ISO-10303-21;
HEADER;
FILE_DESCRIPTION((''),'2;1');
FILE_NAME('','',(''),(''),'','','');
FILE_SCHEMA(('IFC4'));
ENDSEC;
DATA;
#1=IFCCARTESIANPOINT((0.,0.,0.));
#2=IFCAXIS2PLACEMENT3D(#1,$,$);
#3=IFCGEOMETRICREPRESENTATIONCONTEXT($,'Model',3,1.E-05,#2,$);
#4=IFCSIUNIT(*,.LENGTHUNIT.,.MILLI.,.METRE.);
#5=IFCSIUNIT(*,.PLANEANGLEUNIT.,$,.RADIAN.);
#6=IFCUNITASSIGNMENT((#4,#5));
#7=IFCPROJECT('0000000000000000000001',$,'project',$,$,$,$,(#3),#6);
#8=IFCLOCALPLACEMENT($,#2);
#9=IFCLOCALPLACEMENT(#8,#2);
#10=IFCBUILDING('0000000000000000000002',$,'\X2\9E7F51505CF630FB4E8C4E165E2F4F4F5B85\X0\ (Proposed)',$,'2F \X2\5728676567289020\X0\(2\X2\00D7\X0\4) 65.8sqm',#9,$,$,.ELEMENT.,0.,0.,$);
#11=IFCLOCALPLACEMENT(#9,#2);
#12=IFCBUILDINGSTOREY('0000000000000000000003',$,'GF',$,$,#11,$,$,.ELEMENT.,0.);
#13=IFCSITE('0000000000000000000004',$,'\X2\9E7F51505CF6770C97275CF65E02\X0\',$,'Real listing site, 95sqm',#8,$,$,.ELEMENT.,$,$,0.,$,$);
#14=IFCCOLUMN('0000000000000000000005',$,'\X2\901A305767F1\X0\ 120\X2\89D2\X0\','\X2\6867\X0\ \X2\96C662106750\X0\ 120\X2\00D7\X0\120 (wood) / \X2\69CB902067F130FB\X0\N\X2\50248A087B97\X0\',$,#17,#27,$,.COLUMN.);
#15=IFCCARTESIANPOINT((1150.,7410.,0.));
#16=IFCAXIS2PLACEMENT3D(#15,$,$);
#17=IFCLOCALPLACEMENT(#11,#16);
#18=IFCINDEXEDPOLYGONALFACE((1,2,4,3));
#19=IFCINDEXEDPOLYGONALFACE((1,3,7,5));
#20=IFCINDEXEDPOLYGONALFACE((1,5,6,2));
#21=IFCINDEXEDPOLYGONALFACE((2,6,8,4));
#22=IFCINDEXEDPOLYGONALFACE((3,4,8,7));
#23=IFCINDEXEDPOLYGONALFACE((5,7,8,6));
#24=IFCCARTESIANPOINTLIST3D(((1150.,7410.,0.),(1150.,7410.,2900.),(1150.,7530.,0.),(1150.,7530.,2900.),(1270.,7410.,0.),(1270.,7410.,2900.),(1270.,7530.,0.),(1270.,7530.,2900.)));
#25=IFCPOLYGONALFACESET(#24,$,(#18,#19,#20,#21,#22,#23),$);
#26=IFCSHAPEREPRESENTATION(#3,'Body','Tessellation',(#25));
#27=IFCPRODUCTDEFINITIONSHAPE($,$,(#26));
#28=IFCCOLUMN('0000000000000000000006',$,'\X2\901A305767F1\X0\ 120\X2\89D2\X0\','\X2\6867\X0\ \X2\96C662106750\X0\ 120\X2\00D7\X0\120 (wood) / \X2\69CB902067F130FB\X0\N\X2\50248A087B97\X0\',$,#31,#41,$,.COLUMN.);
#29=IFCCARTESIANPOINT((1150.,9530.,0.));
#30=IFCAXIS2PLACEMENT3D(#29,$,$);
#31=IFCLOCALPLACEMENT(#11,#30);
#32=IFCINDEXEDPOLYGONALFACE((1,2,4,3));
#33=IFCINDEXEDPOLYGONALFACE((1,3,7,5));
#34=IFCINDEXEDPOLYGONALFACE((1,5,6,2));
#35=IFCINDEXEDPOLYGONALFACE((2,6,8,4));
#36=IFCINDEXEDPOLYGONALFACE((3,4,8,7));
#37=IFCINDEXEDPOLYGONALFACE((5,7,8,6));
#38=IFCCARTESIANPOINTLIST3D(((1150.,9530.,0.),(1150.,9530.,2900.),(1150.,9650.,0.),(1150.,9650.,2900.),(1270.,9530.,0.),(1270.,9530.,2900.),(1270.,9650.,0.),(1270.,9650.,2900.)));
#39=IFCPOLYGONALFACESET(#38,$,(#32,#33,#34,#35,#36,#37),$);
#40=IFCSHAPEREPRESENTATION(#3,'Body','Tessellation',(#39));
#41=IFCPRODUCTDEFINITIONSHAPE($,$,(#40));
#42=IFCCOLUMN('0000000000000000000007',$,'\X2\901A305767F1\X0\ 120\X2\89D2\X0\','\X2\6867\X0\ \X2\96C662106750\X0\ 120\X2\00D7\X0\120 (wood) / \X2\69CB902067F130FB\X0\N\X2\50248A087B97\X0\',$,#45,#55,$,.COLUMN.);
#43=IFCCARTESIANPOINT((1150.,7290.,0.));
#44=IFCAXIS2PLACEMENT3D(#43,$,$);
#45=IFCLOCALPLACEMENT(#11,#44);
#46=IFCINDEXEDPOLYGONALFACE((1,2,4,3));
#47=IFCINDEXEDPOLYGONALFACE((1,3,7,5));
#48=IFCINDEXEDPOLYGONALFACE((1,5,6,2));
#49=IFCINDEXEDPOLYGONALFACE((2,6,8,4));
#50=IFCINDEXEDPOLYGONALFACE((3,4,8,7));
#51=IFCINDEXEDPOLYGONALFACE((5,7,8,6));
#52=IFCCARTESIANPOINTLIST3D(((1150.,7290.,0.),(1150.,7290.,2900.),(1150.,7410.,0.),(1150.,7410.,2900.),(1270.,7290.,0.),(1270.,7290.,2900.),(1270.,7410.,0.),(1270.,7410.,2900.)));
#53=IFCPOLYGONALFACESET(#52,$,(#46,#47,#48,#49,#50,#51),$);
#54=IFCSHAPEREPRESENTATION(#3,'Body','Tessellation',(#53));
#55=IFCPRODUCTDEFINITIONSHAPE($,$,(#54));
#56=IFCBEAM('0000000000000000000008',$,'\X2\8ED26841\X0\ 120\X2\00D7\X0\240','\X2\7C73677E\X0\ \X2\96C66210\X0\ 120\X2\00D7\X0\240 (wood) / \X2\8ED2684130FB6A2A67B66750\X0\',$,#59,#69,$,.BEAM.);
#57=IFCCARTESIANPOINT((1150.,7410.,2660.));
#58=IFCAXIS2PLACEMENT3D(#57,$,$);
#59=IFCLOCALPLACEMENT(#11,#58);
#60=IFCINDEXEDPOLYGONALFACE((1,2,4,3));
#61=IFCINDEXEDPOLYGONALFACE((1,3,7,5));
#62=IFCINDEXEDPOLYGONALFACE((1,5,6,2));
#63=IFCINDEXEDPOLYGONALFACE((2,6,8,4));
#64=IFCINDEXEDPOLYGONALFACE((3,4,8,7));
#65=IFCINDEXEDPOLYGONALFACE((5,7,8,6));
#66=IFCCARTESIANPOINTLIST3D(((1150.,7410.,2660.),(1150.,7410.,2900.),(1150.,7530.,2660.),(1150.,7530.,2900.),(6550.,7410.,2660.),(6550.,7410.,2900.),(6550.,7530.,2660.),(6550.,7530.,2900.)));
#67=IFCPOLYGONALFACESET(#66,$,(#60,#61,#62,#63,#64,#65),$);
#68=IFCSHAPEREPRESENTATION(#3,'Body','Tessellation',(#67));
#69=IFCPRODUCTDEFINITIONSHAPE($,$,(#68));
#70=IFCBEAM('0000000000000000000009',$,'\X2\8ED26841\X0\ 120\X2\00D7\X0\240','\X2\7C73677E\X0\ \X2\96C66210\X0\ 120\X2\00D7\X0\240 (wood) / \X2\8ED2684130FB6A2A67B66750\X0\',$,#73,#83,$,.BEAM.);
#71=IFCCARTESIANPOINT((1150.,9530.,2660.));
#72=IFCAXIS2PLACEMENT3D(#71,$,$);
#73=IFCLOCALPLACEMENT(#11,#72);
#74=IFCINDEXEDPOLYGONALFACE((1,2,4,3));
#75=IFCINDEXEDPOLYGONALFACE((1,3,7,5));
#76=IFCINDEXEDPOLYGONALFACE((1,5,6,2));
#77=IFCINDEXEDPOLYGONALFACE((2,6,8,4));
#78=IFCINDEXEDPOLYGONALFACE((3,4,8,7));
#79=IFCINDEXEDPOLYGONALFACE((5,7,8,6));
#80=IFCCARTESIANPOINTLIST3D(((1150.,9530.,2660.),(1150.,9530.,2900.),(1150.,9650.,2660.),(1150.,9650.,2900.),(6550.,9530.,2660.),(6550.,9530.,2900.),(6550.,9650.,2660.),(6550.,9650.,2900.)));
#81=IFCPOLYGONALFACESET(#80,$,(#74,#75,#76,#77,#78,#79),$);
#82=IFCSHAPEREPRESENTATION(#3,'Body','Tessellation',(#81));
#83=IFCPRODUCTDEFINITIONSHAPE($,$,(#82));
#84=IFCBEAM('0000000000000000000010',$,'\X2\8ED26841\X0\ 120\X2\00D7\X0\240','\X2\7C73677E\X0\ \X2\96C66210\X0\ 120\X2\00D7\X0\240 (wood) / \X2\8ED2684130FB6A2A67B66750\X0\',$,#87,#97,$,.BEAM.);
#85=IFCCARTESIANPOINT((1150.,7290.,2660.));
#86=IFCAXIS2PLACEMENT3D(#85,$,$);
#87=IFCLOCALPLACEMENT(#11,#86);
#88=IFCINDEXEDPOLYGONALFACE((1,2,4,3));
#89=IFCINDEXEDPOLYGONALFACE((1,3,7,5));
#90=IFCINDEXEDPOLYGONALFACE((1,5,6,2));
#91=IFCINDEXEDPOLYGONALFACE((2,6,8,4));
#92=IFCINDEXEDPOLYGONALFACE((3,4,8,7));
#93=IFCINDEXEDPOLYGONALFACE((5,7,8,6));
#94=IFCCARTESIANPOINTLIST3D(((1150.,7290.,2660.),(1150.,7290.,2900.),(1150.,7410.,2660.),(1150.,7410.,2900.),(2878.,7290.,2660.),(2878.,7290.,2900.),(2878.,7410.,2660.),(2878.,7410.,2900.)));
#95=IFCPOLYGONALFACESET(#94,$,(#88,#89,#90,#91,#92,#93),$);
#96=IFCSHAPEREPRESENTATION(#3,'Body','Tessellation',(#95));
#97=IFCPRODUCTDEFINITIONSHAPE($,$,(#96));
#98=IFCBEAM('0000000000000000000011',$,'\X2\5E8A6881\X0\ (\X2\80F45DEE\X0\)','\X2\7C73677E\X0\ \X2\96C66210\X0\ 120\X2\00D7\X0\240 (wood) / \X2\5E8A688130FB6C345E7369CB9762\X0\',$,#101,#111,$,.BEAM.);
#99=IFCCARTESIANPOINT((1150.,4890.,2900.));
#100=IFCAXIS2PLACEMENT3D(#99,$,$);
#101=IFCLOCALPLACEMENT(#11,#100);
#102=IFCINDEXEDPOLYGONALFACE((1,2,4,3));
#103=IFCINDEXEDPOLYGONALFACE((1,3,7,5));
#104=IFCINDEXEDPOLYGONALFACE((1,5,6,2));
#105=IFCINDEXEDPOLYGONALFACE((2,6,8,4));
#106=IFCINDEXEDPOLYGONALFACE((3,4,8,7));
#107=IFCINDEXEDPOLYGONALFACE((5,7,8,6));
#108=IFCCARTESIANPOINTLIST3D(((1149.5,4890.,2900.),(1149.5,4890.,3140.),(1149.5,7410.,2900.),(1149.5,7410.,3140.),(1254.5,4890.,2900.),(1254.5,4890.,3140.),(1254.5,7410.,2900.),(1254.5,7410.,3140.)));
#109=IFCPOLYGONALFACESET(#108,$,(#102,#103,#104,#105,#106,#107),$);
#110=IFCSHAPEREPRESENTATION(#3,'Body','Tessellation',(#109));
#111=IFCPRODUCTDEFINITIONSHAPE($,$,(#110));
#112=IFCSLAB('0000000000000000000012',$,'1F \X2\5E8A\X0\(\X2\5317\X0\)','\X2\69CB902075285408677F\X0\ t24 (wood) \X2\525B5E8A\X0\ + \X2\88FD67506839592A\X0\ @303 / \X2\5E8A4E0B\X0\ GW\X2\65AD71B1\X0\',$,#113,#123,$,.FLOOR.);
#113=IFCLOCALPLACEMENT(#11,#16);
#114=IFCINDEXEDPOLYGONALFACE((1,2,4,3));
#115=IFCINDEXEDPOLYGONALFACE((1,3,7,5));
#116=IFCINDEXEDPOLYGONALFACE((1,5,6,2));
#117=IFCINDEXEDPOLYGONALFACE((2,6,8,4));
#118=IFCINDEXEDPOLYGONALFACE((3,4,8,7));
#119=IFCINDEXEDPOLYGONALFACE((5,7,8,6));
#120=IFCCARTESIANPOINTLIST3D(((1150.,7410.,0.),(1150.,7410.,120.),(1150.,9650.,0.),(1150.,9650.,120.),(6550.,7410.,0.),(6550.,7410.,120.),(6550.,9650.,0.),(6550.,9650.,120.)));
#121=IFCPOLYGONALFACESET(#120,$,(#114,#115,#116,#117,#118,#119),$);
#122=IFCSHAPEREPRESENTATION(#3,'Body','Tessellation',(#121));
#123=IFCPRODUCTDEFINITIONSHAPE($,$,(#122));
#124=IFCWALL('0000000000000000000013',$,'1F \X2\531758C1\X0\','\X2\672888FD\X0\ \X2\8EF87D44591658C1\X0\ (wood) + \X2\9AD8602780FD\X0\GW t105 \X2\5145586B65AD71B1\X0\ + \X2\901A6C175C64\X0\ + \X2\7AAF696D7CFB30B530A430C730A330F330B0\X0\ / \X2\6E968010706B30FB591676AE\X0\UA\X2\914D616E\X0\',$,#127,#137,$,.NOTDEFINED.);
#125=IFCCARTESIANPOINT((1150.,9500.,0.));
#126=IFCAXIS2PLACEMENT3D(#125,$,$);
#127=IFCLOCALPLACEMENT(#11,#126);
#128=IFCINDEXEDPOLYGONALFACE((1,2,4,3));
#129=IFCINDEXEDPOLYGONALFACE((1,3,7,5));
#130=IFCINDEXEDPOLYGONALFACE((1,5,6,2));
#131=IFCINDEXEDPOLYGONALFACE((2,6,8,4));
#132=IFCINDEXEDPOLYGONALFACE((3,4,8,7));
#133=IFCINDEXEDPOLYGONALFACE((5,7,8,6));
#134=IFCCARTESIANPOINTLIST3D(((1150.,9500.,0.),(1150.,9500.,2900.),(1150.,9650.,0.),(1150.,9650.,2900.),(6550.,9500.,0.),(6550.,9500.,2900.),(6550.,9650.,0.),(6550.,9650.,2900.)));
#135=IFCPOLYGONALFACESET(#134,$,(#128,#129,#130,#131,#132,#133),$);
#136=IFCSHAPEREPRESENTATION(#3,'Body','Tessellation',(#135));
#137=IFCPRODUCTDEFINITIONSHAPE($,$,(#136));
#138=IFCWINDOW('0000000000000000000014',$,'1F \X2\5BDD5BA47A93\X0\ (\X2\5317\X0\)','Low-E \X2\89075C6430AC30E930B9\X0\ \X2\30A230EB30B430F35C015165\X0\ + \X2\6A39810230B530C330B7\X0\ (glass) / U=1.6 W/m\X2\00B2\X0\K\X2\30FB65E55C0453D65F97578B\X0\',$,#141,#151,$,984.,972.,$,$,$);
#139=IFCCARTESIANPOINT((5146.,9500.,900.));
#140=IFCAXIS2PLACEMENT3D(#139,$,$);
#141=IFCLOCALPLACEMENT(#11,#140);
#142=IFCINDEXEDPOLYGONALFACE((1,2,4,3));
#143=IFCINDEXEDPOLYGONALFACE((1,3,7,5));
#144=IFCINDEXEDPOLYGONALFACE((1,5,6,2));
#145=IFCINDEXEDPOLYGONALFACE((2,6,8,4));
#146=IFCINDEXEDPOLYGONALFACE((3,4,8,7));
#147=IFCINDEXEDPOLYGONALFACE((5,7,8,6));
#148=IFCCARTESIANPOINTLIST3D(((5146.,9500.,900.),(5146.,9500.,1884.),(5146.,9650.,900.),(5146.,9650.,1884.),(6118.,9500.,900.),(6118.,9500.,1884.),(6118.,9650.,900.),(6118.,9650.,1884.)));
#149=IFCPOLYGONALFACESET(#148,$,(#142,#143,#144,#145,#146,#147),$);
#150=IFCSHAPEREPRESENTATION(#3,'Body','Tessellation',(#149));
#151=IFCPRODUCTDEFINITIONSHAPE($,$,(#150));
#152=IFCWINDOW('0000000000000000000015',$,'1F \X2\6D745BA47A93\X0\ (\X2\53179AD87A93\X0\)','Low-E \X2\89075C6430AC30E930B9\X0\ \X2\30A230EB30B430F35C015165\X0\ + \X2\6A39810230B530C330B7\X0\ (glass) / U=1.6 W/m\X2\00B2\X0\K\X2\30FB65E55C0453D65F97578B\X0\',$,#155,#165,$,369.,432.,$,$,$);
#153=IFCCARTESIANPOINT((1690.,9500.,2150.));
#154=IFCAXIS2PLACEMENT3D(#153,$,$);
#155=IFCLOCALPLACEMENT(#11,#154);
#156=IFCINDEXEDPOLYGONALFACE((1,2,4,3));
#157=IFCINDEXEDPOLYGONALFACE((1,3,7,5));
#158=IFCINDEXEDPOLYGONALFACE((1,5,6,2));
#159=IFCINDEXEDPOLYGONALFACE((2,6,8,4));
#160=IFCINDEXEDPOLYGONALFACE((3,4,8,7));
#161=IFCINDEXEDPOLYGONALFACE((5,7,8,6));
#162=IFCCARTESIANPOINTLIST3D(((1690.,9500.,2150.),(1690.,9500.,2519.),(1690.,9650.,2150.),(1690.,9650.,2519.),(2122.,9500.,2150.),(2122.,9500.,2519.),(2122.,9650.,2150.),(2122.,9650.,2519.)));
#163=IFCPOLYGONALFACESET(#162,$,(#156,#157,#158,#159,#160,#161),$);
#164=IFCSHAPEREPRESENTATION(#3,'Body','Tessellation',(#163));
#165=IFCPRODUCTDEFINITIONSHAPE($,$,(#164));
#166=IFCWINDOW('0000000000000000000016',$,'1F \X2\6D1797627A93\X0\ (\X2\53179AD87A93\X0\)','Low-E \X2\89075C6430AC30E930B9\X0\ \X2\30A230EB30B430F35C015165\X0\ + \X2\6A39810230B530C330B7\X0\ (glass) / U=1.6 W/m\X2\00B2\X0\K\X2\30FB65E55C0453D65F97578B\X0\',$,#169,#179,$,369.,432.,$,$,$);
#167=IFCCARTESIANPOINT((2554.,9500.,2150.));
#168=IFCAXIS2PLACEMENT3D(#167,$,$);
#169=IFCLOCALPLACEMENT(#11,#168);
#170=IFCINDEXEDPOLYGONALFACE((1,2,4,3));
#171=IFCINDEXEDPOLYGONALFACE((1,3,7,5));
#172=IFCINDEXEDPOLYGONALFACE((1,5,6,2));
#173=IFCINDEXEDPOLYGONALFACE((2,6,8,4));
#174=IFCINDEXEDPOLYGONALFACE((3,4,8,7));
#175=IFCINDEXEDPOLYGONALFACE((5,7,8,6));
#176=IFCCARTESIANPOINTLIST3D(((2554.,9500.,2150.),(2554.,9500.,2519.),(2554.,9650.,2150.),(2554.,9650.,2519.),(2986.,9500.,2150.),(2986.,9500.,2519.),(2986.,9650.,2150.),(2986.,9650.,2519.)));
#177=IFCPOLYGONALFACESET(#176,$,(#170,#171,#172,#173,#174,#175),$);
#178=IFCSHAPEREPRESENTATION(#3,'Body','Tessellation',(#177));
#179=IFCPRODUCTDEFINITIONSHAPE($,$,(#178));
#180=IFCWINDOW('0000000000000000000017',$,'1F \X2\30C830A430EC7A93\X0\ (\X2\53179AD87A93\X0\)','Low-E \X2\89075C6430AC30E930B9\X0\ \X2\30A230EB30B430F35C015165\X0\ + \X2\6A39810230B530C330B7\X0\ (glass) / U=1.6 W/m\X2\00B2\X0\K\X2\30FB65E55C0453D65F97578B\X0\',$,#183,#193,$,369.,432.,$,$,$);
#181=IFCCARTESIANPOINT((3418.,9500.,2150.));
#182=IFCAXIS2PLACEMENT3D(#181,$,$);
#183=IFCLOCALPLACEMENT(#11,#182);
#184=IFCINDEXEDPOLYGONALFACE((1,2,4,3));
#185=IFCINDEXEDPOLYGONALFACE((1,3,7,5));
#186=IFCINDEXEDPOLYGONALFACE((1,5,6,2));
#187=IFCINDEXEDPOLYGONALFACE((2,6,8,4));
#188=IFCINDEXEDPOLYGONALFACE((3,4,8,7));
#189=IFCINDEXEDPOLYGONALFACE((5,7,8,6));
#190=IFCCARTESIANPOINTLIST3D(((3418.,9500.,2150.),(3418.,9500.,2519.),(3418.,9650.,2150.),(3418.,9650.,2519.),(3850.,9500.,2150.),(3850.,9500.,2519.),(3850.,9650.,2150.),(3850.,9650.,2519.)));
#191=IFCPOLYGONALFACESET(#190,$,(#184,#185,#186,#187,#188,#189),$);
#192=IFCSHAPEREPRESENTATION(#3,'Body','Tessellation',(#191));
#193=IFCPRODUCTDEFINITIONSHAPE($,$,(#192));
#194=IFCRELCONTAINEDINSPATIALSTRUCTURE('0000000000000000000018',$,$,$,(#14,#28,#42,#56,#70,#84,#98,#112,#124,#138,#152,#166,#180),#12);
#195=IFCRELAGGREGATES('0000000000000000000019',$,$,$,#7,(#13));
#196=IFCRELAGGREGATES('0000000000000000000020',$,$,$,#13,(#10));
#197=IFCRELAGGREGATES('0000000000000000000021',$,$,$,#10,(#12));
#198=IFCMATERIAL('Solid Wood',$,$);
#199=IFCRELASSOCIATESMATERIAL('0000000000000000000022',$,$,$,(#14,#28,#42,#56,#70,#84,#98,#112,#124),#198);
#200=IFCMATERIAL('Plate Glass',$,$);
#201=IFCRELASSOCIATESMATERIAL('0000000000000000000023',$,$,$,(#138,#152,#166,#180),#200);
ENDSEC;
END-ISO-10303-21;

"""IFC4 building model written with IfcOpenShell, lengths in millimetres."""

from ifc_helpers import new_model, si_unit, frame, frame_2d, origin, place, context, project, spatial, rectangle, extrude, material, element, fill, save


model = new_model("IFC4")

# Units and contexts
model_context = context("Model", 3, precision=1e-05, world=origin())
ifc_project = project(units=[si_unit("LENGTHUNIT", "METRE", prefix="MILLI"), si_unit("PLANEANGLEUNIT", "RADIAN")], contexts=[model_context])

# Site, building, storey
site_placement = place(None, origin())
site = spatial("IfcSite", under=ifc_project, at=site_placement, Name="鹿児島県霧島市", ObjectType="Real listing site, 95sqm", CompositionType="ELEMENT", RefElevation=0.0)
building_placement = place(site_placement, origin())
building = spatial("IfcBuilding", under=site, at=building_placement, Name="鹿児島・二世帯住宅 (Proposed)", ObjectType="2F 在来木造(2×4) 65.8sqm", CompositionType="ELEMENT", ElevationOfRefHeight=0.0, ElevationOfTerrain=0.0)
storey_placement = place(building_placement, origin())
storey = spatial("IfcBuildingStorey", under=building, at=storey_placement, Name="GF", CompositionType="ELEMENT", Elevation=0.0)

# Columns
ifc_material_1 = material(Name="Solid Wood")
column_1_placement = place(storey_placement, frame((1150.0, 7410.0, 0.0)))
element("IfcColumn", 1, at=column_1_placement, inside=storey, material=ifc_material_1, Name="通し柱 120角", Description="桧 集成材 120×120 (wood) / 構造柱・N値計算", PredefinedType="COLUMN", context=model_context, shape_type="SweptSolid", body=[
    extrude(rectangle(XDim=120.0, YDim=120.0, at=frame_2d((60.0, 60.0))), frame((1150.0, 7410.0, 0.0)), (0.0, 0.0, 1.0), 2900.0),
])
column_2_placement = place(storey_placement, frame((1150.0, 9530.0, 0.0)))
element("IfcColumn", 2, at=column_2_placement, inside=storey, material=ifc_material_1, Name="通し柱 120角", Description="桧 集成材 120×120 (wood) / 構造柱・N値計算", PredefinedType="COLUMN", context=model_context, shape_type="SweptSolid", body=[
    extrude(rectangle(XDim=120.0, YDim=120.0, at=frame_2d((60.0, 60.0))), frame((1150.0, 9530.0, 0.0)), (0.0, 0.0, 1.0), 2900.0),
])
column_3_placement = place(storey_placement, frame((1150.0, 7290.0, 0.0)))
element("IfcColumn", 3, at=column_3_placement, inside=storey, material=ifc_material_1, Name="通し柱 120角", Description="桧 集成材 120×120 (wood) / 構造柱・N値計算", PredefinedType="COLUMN", context=model_context, shape_type="SweptSolid", body=[
    extrude(rectangle(XDim=120.0, YDim=120.0, at=frame_2d((60.0, 60.0))), frame((1150.0, 7290.0, 0.0)), (0.0, 0.0, 1.0), 2900.0),
])

# Beams
beam_1_placement = place(storey_placement, frame((1150.0, 7410.0, 2660.0)))
element("IfcBeam", 4, at=beam_1_placement, inside=storey, material=ifc_material_1, Name="軒桁 120×240", Description="米松 集成 120×240 (wood) / 軒桁・横架材", PredefinedType="BEAM", context=model_context, shape_type="SweptSolid", body=[
    extrude(rectangle(XDim=5400.0, YDim=120.0, at=frame_2d((2700.0, 60.0))), frame((1150.0, 7410.0, 2660.0)), (0.0, 0.0, 1.0), 240.0),
])
beam_2_placement = place(storey_placement, frame((1150.0, 9530.0, 2660.0)))
element("IfcBeam", 5, at=beam_2_placement, inside=storey, material=ifc_material_1, Name="軒桁 120×240", Description="米松 集成 120×240 (wood) / 軒桁・横架材", PredefinedType="BEAM", context=model_context, shape_type="SweptSolid", body=[
    extrude(rectangle(XDim=5400.0, YDim=120.0, at=frame_2d((2700.0, 60.0))), frame((1150.0, 9530.0, 2660.0)), (0.0, 0.0, 1.0), 240.0),
])
beam_3_placement = place(storey_placement, frame((1150.0, 7290.0, 2660.0)))
element("IfcBeam", 6, at=beam_3_placement, inside=storey, material=ifc_material_1, Name="軒桁 120×240", Description="米松 集成 120×240 (wood) / 軒桁・横架材", PredefinedType="BEAM", context=model_context, shape_type="SweptSolid", body=[
    extrude(rectangle(XDim=1728.0, YDim=120.0, at=frame_2d((864.0, 60.0))), frame((1150.0, 7290.0, 2660.0)), (0.0, 0.0, 1.0), 240.0),
])
beam_4_placement = place(storey_placement, frame((1150.0, 4890.0, 2900.0)))
element("IfcBeam", 7, at=beam_4_placement, inside=storey, material=ifc_material_1, Name="床梁 (胴差)", Description="米松 集成 120×240 (wood) / 床梁・水平構面", PredefinedType="BEAM", context=model_context, shape_type="SweptSolid", body=[
    extrude(rectangle(XDim=105.0, YDim=2520.0, at=frame_2d((52.0, 1260.0))), frame((1150.0, 4890.0, 2900.0)), (0.0, 0.0, 1.0), 240.0),
])

# Slab
slab_placement = place(storey_placement, frame((1150.0, 7410.0, 0.0)))
element("IfcSlab", 8, at=slab_placement, inside=storey, material=ifc_material_1, Name="1F 床(北)", Description="構造用合板 t24 (wood) 剛床 + 製材根太 @303 / 床下 GW断熱", PredefinedType="FLOOR", context=model_context, shape_type="SweptSolid", body=[
    extrude(rectangle(XDim=5400.0, YDim=2240.0, at=frame_2d((2700.0, 1120.0))), frame((1150.0, 7410.0, 0.0)), (0.0, 0.0, 1.0), 120.0),
])

# Wall, openings, windows
wall_1_placement = place(storey_placement, frame((1150.0, 9500.0, 0.0)))
wall_1 = element("IfcWall", 9, at=wall_1_placement, inside=storey, material=ifc_material_1, Name="1F 北壁", Description="木製 軸組外壁 (wood) + 高性能GW t105 充填断熱 + 通気層 + 窯業系サイディング / 準耐火・外皮UA配慮", PredefinedType="NOTDEFINED", context=model_context, shape_type="SweptSolid", body=[
    extrude(rectangle(XDim=5400.0, YDim=150.0, at=frame_2d((2700.0, 75.0))), frame((1150.0, 9500.0, 0.0)), (0.0, 0.0, 1.0), 2900.0),
])
opening_1_placement = place(storey_placement, frame((5146.0, 9500.0, 900.0)))
opening_1 = element("IfcOpeningElement", 10, at=opening_1_placement, cuts=wall_1, PredefinedType="NOTDEFINED", context=model_context, shape_type="SweptSolid", body=[
    extrude(rectangle(XDim=972.0, YDim=150.0, at=frame_2d((486.0, 75.0))), frame((5146.0, 9500.0, 900.0)), (0.0, 0.0, 1.0), 984.0),
])
opening_2_placement = place(storey_placement, frame((1690.0, 9500.0, 2150.0)))
opening_2 = element("IfcOpeningElement", 11, at=opening_2_placement, cuts=wall_1, PredefinedType="NOTDEFINED", context=model_context, shape_type="SweptSolid", body=[
    extrude(rectangle(XDim=432.0, YDim=150.0, at=frame_2d((216.0, 75.0))), frame((1690.0, 9500.0, 2150.0)), (0.0, 0.0, 1.0), 369.0),
])
opening_3_placement = place(storey_placement, frame((2554.0, 9500.0, 2150.0)))
opening_3 = element("IfcOpeningElement", 12, at=opening_3_placement, cuts=wall_1, PredefinedType="NOTDEFINED", context=model_context, shape_type="SweptSolid", body=[
    extrude(rectangle(XDim=432.0, YDim=150.0, at=frame_2d((216.0, 75.0))), frame((2554.0, 9500.0, 2150.0)), (0.0, 0.0, 1.0), 369.0),
])
opening_4_placement = place(storey_placement, frame((3418.0, 9500.0, 2150.0)))
opening_4 = element("IfcOpeningElement", 13, at=opening_4_placement, cuts=wall_1, PredefinedType="NOTDEFINED", context=model_context, shape_type="SweptSolid", body=[
    extrude(rectangle(XDim=432.0, YDim=150.0, at=frame_2d((216.0, 75.0))), frame((3418.0, 9500.0, 2150.0)), (0.0, 0.0, 1.0), 369.0),
])
ifc_material_2 = material(Name="Plate Glass")
window_1_placement = place(storey_placement, frame((5146.0, 9500.0, 900.0)))
window_1 = element("IfcWindow", 14, at=window_1_placement, inside=storey, material=ifc_material_2, Name="1F 寝室窓 (北)", Description="Low-E 複層ガラス アルゴン封入 + 樹脂サッシ (glass) / U=1.6 W/m²K・日射取得型", OverallHeight=984.0, OverallWidth=972.0, context=model_context, shape_type="SweptSolid", body=[
    extrude(rectangle(XDim=972.0, YDim=150.0, at=frame_2d((486.0, 75.0))), frame((5146.0, 9500.0, 900.0)), (0.0, 0.0, 1.0), 984.0),
])
fill(opening_1, window_1)
window_2_placement = place(storey_placement, frame((1690.0, 9500.0, 2150.0)))
window_2 = element("IfcWindow", 15, at=window_2_placement, inside=storey, material=ifc_material_2, Name="1F 浴室窓 (北高窓)", Description="Low-E 複層ガラス アルゴン封入 + 樹脂サッシ (glass) / U=1.6 W/m²K・日射取得型", OverallHeight=369.0, OverallWidth=432.0, context=model_context, shape_type="SweptSolid", body=[
    extrude(rectangle(XDim=432.0, YDim=150.0, at=frame_2d((216.0, 75.0))), frame((1690.0, 9500.0, 2150.0)), (0.0, 0.0, 1.0), 369.0),
])
fill(opening_2, window_2)
window_3_placement = place(storey_placement, frame((2554.0, 9500.0, 2150.0)))
window_3 = element("IfcWindow", 16, at=window_3_placement, inside=storey, material=ifc_material_2, Name="1F 洗面窓 (北高窓)", Description="Low-E 複層ガラス アルゴン封入 + 樹脂サッシ (glass) / U=1.6 W/m²K・日射取得型", OverallHeight=369.0, OverallWidth=432.0, context=model_context, shape_type="SweptSolid", body=[
    extrude(rectangle(XDim=432.0, YDim=150.0, at=frame_2d((216.0, 75.0))), frame((2554.0, 9500.0, 2150.0)), (0.0, 0.0, 1.0), 369.0),
])
fill(opening_3, window_3)
window_4_placement = place(storey_placement, frame((3418.0, 9500.0, 2150.0)))
window_4 = element("IfcWindow", 17, at=window_4_placement, inside=storey, material=ifc_material_2, Name="1F トイレ窓 (北高窓)", Description="Low-E 複層ガラス アルゴン封入 + 樹脂サッシ (glass) / U=1.6 W/m²K・日射取得型", OverallHeight=369.0, OverallWidth=432.0, context=model_context, shape_type="SweptSolid", body=[
    extrude(rectangle(XDim=432.0, YDim=150.0, at=frame_2d((216.0, 75.0))), frame((3418.0, 9500.0, 2150.0)), (0.0, 0.0, 1.0), 369.0),
])
fill(opening_4, window_4)

save(model, "model.ifc")
